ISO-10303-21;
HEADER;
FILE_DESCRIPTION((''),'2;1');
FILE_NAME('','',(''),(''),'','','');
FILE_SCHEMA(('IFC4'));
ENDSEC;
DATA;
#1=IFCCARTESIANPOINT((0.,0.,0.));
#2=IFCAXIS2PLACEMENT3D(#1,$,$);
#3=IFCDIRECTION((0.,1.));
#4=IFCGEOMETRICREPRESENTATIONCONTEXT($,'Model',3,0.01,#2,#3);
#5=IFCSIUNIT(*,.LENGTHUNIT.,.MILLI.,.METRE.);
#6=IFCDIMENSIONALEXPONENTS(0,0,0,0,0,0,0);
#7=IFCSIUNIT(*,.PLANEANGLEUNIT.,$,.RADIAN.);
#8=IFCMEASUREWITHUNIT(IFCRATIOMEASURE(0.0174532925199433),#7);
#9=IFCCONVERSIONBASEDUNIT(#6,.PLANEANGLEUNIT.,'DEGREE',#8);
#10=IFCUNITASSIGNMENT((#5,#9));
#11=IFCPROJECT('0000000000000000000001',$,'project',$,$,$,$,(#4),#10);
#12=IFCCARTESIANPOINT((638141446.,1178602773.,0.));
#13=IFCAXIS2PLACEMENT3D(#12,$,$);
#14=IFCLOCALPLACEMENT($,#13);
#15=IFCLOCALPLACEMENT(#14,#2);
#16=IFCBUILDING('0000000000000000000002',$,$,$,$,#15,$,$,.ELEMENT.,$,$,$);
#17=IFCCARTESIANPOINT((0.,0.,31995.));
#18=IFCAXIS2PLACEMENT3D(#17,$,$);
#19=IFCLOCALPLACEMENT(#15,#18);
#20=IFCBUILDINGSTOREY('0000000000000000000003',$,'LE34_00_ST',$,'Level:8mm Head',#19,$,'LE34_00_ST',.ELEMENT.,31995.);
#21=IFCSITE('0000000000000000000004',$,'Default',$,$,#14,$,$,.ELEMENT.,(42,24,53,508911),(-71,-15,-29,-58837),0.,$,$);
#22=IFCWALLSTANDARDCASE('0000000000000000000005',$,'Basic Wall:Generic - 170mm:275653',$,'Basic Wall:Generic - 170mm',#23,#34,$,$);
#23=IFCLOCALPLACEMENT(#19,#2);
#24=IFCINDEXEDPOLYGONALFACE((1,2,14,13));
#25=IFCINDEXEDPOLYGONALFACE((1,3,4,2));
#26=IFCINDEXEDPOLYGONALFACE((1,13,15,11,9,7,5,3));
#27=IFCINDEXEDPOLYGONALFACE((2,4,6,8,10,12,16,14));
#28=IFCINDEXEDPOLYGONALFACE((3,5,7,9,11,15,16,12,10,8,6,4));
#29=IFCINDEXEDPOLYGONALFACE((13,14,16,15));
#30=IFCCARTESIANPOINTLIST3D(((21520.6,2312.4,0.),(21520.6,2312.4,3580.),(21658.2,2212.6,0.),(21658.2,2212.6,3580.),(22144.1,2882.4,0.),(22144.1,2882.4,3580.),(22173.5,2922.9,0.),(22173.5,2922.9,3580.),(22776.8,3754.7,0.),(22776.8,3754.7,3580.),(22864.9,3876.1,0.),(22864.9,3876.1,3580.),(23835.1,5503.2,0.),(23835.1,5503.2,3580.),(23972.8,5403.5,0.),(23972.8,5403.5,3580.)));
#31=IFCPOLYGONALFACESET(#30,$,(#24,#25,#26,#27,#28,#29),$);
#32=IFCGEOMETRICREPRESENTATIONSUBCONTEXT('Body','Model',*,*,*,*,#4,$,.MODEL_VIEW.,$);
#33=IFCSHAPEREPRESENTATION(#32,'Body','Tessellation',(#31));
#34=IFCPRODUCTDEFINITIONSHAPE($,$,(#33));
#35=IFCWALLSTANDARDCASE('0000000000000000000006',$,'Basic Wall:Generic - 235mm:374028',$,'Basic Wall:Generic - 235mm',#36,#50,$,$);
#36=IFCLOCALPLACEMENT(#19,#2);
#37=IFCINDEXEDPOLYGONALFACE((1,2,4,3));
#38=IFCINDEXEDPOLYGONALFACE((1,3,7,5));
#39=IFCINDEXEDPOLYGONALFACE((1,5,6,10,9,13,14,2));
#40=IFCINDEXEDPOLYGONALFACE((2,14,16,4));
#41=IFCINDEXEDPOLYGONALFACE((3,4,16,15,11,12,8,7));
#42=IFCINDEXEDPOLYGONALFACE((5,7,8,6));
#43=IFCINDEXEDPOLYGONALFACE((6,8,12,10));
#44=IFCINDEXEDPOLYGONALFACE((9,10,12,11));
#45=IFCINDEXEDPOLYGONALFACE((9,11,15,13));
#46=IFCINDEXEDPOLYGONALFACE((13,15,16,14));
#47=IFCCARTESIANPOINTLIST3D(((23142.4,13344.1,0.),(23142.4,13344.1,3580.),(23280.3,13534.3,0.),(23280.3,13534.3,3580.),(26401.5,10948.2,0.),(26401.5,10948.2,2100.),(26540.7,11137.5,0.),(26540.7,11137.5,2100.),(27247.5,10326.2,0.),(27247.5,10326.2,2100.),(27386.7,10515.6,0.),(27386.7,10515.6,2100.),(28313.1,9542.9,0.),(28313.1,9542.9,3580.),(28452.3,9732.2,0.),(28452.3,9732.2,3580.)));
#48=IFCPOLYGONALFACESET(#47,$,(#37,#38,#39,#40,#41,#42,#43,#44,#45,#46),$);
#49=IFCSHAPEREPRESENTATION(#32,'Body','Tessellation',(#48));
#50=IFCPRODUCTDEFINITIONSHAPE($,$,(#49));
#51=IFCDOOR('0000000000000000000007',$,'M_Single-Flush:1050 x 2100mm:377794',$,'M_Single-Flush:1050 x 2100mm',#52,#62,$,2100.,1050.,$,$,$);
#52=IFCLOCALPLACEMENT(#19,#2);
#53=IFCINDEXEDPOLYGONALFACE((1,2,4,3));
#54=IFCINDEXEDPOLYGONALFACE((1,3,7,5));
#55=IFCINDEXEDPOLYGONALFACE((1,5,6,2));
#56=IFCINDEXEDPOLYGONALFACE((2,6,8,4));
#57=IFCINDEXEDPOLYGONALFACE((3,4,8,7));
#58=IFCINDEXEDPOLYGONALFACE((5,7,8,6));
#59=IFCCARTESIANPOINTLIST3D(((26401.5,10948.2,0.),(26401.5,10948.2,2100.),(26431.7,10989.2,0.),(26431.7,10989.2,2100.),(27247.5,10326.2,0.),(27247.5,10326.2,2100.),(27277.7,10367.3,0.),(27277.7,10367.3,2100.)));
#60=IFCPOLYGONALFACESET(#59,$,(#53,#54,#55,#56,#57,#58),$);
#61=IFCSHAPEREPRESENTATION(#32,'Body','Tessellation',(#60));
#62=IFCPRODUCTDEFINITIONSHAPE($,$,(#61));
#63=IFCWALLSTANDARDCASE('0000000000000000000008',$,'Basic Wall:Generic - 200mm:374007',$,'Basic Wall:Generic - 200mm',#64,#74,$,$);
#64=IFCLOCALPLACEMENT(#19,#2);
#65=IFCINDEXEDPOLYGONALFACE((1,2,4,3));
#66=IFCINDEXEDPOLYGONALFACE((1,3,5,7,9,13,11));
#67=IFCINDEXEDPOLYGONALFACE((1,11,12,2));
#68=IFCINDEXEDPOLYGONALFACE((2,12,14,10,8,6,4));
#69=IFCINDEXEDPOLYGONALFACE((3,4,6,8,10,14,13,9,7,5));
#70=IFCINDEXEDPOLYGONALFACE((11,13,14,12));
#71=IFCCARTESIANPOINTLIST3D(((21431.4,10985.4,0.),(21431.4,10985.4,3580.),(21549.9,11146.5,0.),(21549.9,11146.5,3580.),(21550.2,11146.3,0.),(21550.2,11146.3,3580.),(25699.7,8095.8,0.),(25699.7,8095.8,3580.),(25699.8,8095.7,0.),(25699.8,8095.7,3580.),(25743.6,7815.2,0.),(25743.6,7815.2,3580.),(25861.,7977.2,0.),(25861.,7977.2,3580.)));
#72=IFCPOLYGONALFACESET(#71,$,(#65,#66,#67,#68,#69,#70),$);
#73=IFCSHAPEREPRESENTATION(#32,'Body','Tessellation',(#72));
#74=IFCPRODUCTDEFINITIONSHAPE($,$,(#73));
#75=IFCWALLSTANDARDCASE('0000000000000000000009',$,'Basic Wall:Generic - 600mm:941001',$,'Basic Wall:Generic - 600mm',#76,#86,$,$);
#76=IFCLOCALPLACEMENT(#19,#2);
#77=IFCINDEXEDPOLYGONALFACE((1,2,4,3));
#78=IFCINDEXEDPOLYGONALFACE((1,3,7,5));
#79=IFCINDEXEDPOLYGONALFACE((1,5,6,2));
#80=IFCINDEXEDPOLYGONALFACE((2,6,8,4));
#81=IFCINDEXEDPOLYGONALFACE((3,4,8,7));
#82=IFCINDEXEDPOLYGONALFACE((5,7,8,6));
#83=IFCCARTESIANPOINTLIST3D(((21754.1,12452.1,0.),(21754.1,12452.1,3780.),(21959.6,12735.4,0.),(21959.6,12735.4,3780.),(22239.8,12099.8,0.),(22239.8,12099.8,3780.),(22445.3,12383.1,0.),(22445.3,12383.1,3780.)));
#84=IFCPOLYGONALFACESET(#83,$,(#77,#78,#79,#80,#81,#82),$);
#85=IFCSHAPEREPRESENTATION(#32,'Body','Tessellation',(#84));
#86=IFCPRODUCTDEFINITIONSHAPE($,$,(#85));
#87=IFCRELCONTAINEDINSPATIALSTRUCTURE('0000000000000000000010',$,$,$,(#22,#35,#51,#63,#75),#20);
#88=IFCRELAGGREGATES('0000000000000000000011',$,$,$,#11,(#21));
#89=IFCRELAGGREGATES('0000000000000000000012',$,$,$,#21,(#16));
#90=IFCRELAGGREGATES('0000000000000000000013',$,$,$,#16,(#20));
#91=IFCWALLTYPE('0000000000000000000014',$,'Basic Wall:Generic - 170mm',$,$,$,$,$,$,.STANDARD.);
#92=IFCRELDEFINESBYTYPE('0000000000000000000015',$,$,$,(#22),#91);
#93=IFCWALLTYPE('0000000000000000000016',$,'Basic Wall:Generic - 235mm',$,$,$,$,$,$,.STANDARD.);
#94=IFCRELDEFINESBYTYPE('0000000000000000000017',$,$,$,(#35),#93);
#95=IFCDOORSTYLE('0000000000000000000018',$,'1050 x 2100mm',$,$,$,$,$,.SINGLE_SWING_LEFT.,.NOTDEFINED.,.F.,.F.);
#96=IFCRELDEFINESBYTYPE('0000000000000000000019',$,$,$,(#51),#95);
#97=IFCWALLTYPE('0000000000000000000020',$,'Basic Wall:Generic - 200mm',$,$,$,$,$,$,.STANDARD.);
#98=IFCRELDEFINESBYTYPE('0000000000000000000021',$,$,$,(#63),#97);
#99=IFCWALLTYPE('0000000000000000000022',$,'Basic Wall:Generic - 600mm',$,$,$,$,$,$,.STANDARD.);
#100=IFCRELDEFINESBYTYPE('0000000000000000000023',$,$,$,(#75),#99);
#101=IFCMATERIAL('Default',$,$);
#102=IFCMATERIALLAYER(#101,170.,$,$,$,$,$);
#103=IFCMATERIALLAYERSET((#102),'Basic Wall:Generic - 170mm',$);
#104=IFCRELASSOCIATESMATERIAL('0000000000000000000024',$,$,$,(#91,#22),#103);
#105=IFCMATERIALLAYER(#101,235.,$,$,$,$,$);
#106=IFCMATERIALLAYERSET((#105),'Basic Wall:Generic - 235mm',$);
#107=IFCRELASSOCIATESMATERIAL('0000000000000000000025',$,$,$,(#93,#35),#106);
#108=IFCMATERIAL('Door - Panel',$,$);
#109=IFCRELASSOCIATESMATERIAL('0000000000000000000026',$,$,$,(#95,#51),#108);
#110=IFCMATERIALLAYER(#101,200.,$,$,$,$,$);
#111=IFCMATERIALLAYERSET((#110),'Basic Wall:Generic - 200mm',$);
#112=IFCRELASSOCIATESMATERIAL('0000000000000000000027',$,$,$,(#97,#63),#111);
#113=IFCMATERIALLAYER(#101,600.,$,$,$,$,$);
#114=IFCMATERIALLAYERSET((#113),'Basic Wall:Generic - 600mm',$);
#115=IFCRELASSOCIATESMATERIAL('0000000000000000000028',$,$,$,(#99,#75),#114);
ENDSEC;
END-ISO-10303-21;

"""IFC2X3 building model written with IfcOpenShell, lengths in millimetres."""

from ifc_helpers import new_model, entity, si_unit, converted_unit, direction, frame, frame_2d, origin, place, context, subcontext, project, spatial, polyline, rectangle, outline, extrude, source, transform, mapped, material, layer, layer_set, layer_usage, type_object, type_shapes, element, fill, save


model = new_model("IFC2X3")

# Units and contexts
model_context = context("Model", 3, precision=0.01, world=origin(), true_north=direction((0.0, 1.0)))
body_context = subcontext(model_context, "Body", "Model", "MODEL_VIEW")
ifc_project = project(units=[si_unit("LENGTHUNIT", "METRE", prefix="MILLI"), converted_unit("PLANEANGLEUNIT", "DEGREE", entity("IfcRatioMeasure", 0.0174532925199433), si_unit("PLANEANGLEUNIT", "RADIAN"), dimensions=[0, 0, 0, 0, 0, 0, 0])], contexts=[model_context])

# Site, building, storey
site_placement = place(None, frame((638141446.0, 1178602773.0, 0.0)))
site = spatial("IfcSite", under=ifc_project, at=site_placement, Name="Default", CompositionType="ELEMENT", RefLatitude=(42, 24, 53, 508911), RefLongitude=(-71, -15, -29, -58837), RefElevation=0.0)
building_placement = place(site_placement, origin())
building = spatial("IfcBuilding", under=site, at=building_placement, CompositionType="ELEMENT")
storey_placement = place(building_placement, frame((0.0, 0.0, 31995.0)))
storey = spatial("IfcBuildingStorey", under=building, at=storey_placement, Name="LE34_00_ST", ObjectType="Level:8mm Head", LongName="LE34_00_ST", CompositionType="ELEMENT", Elevation=31995.0)

# Shared definitions
ifc_material_1 = material(Name="Default")

# Wall
ifc_layer_1 = layer(ifc_material_1, 170.0)
ifc_layer_set_1 = layer_set([ifc_layer_1], Name="Basic Wall:Generic - 170mm")
ifc_layer_usage_1 = layer_usage(ifc_layer_set_1, "AXIS2", "POSITIVE", -85.0)
wall_type_1 = type_object("IfcWallType", Name="Basic Wall:Generic - 170mm", PredefinedType="STANDARD", material=ifc_layer_set_1)
wall_1_placement = place(storey_placement, frame((23904.0, 5453.4, 0.0), z_axis=(0.0, 0.0, 1.0), x_axis=(-0.587164, -0.809468, 0.0)))
element("IfcWallStandardCase", 1, at=wall_1_placement, inside=storey, type_object=wall_type_1, material=ifc_layer_usage_1, Name="Basic Wall:Generic - 170mm:275653", ObjectType="Basic Wall:Generic - 170mm", context=body_context, shape_type="SweptSolid", body=[
    extrude(outline(polyline([(3941.9, -85.0), (3941.9, 85.0), (3114.5, 85.0), (3064.5, 85.0), (2036.9, 85.0), (1886.9, 85.0), (0.0, 85.0), (0.1, -85.0), (3941.9, -85.0)])), origin(), (0.0, 0.0, 1.0), 3580.0),
])

# Wall, opening, door
ifc_layer_2 = layer(ifc_material_1, 235.0)
ifc_layer_set_2 = layer_set([ifc_layer_2], Name="Basic Wall:Generic - 235mm")
ifc_layer_usage_2 = layer_usage(ifc_layer_set_2, "AXIS2", "NEGATIVE", 117.5)
wall_type_2 = type_object("IfcWallType", Name="Basic Wall:Generic - 235mm", PredefinedType="STANDARD", material=ifc_layer_set_2)
wall_2_placement = place(storey_placement, frame((23210.7, 13439.7, 0.0), z_axis=(0.0, 0.0, 1.0), x_axis=(0.805709, -0.592312, 0.0)))
wall_2 = element("IfcWallStandardCase", 2, at=wall_2_placement, inside=storey, type_object=wall_type_2, material=ifc_layer_usage_2, Name="Basic Wall:Generic - 235mm:374028", ObjectType="Basic Wall:Generic - 235mm", context=body_context, shape_type="SweptSolid", body=[
    extrude(outline(polyline([(1.5, -117.5), (5151.8, -117.5), (5351.8, -117.5), (6419.1, -117.5), (6419.1, 117.5), (0.0, 117.5), (1.5, -117.5)])), origin(), (0.0, 0.0, 1.0), 3580.0),
])
opening_1_placement = place(wall_2_placement, frame((5096.6, 117.5, 0.0)))
opening_1 = element("IfcOpeningElement", 3, at=opening_1_placement, cuts=wall_2, ObjectType="Opening", context=body_context, shape_type="SweptSolid", body=[
    extrude(rectangle(XDim=1050.0, YDim=2100.0, at=frame_2d((1050.0, 525.0), x_axis=(0.0, -1.0))), frame((0.0, 0.0, 0.0), z_axis=(0.0, -1.0, 0.0), x_axis=(0.0, 0.0, 1.0)), (0.0, 0.0, 1.0), 235.0),
])
ifc_material_2 = material(Name="Door - Panel")
door_style = type_object("IfcDoorStyle", Name="1050 x 2100mm", ConstructionType="NOTDEFINED", OperationType="SINGLE_SWING_LEFT", ParameterTakesPrecedence=False, Sizeable=False, material=ifc_material_2)
shared_shape = source(origin(), body_context, "Body", "SweptSolid", [
    extrude(rectangle(XDim=1050.0, YDim=51.0, at=frame_2d((0.0, 0.0), x_axis=(1.0, 0.0))), frame((525.0, 209.5, 0.0)), (0.0, 0.0, 1.0), 2100.0),
])
type_shapes(door_style, [shared_shape])
door_placement = place(opening_1_placement, frame((0.0, 0.0, 0.0), z_axis=(0.0, 0.0, 1.0), x_axis=(-1.0, 0.0, 0.0)))
door = element("IfcDoor", 4, at=door_placement, inside=storey, type_object=door_style, material=ifc_material_2, Name="M_Single-Flush:1050 x 2100mm:377794", ObjectType="M_Single-Flush:1050 x 2100mm", OverallHeight=2100.0, OverallWidth=1050.0, context=body_context, shape_type="MappedRepresentation", body=[
    mapped(shared_shape, transform((0.0, 0.0, 0.0), scale=1.0)),
])
fill(opening_1, door)

# Wall
ifc_layer_3 = layer(ifc_material_1, 200.0)
ifc_layer_set_3 = layer_set([ifc_layer_3], Name="Basic Wall:Generic - 200mm")
ifc_layer_usage_3 = layer_usage(ifc_layer_set_3, "AXIS2", "POSITIVE", -100.0)
wall_type_3 = type_object("IfcWallType", Name="Basic Wall:Generic - 200mm", PredefinedType="STANDARD", material=ifc_layer_set_3)
wall_3_placement = place(storey_placement, frame((21490.6, 11065.9, 0.0), z_axis=(0.0, 0.0, 1.0), x_axis=(0.805709, -0.592312, 0.0)))
element("IfcWallStandardCase", 5, at=wall_3_placement, inside=storey, type_object=wall_type_3, material=ifc_layer_usage_3, Name="Basic Wall:Generic - 200mm:374007", ObjectType="Basic Wall:Generic - 200mm", context=body_context, shape_type="SweptSolid", body=[
    extrude(outline(polyline([(5352.1, -100.0), (5350.7, 100.0), (5150.7, 100.0), (5150.5, 100.0), (0.4, 100.0), (0.0, 100.0), (0.0, -100.0), (5352.1, -100.0)])), origin(), (0.0, 0.0, 1.0), 3580.0),
])

# Shared definitions
ifc_layer_4 = layer(ifc_material_1, 600.0)
ifc_layer_set_4 = layer_set([ifc_layer_4], Name="Basic Wall:Generic - 600mm")
wall_type_4 = type_object("IfcWallType", Name="Basic Wall:Generic - 600mm", PredefinedType="STANDARD", material=ifc_layer_set_4)

# Wall
ifc_layer_usage_4 = layer_usage(ifc_layer_set_4, "AXIS2", "NEGATIVE", 300.0)
wall_4_placement = place(storey_placement, frame((21997.0, 12276.0, 0.0), z_axis=(0.0, 0.0, 1.0), x_axis=(0.587164, 0.809468, 0.0)))
element("IfcWallStandardCase", 6, at=wall_4_placement, inside=storey, type_object=wall_type_4, material=ifc_layer_usage_4, Name="Basic Wall:Generic - 600mm:941001", ObjectType="Basic Wall:Generic - 600mm", context=body_context, shape_type="SweptSolid", body=[
    extrude(rectangle(XDim=350.0, YDim=600.0, at=frame_2d((175.0, 0.0), x_axis=(-1.0, 0.0))), origin(), (0.0, 0.0, 1.0), 3780.0),
])

save(model, "model.ifc")
